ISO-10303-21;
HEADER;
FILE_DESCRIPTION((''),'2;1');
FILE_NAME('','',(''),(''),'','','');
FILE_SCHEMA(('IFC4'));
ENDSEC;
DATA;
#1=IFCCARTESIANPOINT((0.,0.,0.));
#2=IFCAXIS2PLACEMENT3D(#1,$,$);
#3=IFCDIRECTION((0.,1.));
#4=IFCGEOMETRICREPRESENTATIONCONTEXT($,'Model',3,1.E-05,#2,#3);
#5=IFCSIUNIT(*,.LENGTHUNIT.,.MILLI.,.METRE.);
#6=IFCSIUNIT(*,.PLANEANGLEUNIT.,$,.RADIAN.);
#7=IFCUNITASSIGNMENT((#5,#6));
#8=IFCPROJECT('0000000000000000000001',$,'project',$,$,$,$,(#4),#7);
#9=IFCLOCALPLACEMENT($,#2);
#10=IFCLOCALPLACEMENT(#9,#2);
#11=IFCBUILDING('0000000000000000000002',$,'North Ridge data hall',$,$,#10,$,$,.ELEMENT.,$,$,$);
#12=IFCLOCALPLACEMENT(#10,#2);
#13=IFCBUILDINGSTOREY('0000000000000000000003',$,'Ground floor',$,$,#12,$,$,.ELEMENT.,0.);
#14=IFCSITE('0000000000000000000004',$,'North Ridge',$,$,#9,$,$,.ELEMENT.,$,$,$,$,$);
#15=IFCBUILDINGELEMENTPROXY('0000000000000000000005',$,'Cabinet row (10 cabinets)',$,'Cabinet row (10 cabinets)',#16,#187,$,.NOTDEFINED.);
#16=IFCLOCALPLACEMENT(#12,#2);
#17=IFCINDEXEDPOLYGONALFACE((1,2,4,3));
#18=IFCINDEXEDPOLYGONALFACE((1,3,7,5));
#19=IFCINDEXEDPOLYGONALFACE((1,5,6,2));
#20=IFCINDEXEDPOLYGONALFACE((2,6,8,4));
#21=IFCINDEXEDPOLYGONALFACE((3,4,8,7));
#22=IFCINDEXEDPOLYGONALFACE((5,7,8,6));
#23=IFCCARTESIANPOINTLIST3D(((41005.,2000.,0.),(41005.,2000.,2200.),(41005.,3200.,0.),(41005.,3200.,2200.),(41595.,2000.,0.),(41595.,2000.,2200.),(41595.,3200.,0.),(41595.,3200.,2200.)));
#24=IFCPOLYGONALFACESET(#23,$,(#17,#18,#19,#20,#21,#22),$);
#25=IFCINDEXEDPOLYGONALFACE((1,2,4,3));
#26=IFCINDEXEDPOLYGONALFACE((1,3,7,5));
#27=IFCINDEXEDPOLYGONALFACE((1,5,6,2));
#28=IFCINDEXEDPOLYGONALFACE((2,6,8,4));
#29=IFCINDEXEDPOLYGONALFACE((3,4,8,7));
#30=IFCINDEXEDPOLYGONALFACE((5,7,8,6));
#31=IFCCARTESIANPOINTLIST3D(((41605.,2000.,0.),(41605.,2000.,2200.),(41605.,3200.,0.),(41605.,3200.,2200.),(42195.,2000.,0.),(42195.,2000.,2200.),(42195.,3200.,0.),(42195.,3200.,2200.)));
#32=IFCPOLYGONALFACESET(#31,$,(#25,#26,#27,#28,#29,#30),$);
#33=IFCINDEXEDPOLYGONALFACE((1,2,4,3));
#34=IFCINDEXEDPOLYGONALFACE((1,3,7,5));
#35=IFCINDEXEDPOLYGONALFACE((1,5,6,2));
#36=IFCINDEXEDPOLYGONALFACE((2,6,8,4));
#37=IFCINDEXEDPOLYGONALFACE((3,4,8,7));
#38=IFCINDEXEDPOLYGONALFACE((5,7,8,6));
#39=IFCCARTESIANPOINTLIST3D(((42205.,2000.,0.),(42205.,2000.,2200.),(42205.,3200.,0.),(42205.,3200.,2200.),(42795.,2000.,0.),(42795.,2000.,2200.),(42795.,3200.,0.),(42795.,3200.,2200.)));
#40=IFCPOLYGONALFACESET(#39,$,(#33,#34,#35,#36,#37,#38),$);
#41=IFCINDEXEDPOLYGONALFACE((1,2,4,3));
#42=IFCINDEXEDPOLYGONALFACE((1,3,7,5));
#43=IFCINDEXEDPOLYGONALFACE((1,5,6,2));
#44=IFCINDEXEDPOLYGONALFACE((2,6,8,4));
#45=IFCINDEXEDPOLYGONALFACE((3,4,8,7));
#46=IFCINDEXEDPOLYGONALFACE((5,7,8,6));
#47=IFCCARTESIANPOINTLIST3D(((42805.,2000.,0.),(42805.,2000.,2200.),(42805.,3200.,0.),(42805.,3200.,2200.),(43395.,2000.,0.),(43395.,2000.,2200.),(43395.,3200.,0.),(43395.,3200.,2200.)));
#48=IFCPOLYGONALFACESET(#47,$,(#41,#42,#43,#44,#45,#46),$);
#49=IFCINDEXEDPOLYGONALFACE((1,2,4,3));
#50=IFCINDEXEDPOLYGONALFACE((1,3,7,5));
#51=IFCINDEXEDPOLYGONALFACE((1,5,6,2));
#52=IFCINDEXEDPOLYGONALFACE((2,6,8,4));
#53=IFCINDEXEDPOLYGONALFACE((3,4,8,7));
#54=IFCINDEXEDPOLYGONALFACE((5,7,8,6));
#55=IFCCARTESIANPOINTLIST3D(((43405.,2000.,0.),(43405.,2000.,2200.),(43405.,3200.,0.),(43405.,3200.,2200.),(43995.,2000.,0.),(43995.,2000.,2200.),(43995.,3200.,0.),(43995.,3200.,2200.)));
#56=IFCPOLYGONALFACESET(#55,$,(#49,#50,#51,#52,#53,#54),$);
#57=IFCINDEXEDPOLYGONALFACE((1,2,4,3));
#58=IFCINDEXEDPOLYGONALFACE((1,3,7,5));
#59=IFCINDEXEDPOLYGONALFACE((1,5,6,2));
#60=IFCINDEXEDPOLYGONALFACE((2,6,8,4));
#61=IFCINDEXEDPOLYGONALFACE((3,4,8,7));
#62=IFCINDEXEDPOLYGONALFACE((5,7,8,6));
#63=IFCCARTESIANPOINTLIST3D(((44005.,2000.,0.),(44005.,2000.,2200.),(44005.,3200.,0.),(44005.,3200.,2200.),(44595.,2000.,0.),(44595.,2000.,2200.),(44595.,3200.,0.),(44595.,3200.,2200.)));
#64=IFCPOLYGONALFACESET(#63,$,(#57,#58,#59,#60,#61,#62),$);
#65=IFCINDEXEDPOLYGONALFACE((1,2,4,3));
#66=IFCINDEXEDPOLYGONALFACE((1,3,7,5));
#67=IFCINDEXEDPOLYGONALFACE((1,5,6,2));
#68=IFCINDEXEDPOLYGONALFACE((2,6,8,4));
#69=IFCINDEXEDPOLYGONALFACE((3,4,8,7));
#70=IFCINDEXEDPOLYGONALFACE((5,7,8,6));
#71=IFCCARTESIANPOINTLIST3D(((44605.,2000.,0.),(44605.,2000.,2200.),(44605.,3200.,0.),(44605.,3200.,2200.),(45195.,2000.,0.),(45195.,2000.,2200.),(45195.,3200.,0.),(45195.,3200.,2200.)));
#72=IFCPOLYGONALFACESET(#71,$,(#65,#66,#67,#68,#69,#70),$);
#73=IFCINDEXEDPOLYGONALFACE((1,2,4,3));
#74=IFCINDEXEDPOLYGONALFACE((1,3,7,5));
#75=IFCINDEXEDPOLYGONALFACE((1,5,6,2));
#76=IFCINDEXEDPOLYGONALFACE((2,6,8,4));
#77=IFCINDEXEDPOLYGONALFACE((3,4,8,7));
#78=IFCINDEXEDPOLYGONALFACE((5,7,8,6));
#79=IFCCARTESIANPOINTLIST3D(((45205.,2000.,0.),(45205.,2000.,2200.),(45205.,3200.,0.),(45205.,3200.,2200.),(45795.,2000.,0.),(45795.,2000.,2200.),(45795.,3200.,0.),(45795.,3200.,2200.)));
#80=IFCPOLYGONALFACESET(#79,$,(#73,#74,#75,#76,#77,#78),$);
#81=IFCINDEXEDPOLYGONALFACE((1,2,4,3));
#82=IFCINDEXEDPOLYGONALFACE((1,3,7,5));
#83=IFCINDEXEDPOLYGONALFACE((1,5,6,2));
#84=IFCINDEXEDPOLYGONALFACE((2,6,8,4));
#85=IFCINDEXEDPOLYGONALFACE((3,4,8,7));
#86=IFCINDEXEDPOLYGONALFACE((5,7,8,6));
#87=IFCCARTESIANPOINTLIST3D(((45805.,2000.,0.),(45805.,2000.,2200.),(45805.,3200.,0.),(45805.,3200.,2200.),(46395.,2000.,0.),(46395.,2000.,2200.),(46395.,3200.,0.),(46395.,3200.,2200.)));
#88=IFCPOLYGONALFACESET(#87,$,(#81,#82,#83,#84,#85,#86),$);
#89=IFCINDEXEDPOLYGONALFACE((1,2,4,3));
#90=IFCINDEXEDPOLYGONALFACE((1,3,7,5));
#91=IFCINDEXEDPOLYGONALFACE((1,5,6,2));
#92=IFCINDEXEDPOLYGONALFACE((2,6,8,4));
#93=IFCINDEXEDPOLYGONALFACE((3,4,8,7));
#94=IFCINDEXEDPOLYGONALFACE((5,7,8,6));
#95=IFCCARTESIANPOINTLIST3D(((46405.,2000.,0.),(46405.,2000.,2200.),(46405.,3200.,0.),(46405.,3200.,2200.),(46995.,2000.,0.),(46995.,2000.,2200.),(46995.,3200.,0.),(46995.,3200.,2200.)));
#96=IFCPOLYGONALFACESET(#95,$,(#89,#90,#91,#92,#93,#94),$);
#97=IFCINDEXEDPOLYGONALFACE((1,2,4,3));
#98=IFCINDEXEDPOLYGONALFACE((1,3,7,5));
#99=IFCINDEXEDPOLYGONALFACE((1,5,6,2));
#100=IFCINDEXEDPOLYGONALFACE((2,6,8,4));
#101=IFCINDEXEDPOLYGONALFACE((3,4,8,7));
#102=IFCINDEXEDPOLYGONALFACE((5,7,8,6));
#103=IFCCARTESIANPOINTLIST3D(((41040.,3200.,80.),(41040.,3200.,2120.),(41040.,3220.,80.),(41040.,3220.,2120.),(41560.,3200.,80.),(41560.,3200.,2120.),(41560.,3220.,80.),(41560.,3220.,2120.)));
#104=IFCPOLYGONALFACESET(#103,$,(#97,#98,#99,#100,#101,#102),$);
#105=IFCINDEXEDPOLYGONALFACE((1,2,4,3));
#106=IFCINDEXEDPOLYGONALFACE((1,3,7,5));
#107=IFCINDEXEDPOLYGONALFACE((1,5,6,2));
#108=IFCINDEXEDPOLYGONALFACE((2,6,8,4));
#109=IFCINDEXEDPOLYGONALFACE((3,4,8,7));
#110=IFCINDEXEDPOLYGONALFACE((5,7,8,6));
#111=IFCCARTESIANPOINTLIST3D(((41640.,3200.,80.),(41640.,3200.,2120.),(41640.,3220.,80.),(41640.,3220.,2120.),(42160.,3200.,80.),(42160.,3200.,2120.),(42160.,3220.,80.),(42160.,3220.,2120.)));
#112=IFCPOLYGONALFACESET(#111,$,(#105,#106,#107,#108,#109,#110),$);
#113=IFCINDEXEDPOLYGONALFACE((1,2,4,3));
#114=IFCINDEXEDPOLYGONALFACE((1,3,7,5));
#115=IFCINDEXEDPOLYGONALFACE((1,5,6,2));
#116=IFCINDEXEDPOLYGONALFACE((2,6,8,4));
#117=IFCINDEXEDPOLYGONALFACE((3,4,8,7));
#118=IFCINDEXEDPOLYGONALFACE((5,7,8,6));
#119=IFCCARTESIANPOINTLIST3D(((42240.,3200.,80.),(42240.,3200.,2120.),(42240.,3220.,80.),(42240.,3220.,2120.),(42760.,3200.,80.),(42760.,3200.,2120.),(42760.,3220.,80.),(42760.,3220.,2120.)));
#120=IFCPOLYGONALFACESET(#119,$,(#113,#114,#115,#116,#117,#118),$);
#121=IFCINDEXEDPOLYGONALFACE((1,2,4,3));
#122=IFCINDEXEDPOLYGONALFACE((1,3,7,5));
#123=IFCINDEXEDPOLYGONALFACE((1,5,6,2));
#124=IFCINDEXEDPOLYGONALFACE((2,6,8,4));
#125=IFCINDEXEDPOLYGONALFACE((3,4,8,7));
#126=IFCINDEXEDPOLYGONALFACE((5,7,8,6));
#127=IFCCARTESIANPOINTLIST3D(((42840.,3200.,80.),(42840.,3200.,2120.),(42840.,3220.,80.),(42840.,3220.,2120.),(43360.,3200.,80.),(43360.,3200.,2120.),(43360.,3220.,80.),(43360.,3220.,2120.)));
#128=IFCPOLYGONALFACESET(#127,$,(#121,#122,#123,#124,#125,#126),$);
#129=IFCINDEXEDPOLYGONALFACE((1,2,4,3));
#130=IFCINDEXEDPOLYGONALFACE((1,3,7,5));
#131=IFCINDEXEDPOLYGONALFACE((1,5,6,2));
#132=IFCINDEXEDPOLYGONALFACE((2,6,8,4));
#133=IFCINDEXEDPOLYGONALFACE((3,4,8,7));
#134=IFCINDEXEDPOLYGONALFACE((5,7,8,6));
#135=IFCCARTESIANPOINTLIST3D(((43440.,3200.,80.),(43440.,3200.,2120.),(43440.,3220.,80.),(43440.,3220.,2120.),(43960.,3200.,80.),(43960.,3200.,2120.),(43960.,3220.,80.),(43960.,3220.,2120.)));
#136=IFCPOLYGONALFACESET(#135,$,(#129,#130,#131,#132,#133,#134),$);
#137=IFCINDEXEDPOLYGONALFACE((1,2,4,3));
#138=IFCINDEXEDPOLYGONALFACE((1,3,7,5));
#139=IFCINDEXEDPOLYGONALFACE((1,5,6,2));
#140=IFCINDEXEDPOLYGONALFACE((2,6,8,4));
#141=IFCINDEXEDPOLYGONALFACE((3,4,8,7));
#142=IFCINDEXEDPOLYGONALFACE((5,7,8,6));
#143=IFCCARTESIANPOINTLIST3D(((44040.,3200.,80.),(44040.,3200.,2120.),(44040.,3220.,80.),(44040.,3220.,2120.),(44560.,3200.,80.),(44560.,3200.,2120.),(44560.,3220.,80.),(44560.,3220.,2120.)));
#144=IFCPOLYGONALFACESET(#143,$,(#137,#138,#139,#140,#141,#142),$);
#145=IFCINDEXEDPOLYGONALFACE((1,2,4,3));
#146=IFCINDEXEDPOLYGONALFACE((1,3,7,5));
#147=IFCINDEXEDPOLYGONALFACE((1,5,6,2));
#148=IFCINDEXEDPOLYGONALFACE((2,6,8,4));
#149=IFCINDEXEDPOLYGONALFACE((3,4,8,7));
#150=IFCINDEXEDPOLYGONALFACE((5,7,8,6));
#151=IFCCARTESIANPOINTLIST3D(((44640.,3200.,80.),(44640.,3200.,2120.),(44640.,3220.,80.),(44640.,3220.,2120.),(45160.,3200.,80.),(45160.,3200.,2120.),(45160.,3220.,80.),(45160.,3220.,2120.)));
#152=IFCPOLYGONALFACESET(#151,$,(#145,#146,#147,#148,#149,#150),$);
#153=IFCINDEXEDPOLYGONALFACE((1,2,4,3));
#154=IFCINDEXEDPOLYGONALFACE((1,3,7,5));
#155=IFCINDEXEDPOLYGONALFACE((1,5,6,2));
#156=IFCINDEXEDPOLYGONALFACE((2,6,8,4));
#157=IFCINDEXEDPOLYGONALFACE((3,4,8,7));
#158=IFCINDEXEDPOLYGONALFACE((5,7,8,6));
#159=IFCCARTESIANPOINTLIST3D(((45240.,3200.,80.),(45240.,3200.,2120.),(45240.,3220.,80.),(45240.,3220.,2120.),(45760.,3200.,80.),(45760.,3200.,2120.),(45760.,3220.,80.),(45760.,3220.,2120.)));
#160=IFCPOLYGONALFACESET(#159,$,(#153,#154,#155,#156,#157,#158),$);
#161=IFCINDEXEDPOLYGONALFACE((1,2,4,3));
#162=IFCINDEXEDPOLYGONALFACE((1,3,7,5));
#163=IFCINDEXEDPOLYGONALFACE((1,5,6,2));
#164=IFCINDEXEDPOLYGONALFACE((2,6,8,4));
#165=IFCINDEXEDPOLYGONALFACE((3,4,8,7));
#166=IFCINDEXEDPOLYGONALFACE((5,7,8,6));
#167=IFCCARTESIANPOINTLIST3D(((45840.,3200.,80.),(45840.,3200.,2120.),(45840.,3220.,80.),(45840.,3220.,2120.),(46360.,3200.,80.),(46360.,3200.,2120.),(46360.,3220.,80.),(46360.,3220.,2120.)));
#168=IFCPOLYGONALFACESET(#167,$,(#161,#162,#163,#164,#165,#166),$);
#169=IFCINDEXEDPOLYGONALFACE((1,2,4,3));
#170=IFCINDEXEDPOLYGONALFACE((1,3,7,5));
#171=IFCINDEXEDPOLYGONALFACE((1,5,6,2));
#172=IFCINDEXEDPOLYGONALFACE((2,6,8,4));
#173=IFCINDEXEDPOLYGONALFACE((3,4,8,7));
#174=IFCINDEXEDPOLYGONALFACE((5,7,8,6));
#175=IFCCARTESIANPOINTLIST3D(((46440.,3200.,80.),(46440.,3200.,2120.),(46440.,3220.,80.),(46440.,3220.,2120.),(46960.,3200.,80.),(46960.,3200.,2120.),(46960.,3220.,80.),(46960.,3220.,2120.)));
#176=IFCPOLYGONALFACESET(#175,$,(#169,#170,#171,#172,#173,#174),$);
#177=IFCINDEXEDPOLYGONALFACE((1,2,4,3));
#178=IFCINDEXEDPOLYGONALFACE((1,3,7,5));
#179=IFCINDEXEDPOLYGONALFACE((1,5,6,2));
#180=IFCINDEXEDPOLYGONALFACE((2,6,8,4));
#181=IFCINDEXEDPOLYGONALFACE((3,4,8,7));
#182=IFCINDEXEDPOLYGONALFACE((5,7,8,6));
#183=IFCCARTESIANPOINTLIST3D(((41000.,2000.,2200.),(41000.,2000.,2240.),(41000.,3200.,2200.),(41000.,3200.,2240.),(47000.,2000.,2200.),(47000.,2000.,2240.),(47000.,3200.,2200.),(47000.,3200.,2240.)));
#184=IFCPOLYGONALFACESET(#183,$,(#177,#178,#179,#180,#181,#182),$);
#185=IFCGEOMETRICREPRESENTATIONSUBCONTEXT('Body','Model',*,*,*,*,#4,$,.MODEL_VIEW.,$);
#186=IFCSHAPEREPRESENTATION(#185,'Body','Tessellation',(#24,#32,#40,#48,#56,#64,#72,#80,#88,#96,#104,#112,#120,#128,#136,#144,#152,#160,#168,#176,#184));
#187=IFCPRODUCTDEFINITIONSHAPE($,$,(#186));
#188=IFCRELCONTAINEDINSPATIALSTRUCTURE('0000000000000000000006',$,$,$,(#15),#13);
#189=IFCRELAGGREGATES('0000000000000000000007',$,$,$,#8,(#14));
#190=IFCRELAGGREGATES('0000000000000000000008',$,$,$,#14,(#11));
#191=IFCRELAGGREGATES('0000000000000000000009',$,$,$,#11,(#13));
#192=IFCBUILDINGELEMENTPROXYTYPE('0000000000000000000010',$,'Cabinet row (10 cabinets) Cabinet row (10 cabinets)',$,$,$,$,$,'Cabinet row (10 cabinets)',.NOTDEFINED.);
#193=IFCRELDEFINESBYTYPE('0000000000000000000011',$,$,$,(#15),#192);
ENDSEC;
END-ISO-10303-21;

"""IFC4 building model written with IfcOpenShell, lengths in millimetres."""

from ifc_helpers import new_model, si_unit, direction, frame, origin, place, context, subcontext, project, spatial, polyline, outline, extrude, source, transform, mapped, type_object, type_shapes, element, save


model = new_model("IFC4")

# Units and contexts
model_context = context("Model", 3, precision=1e-05, world=origin(), true_north=direction((0.0, 1.0)))
body_context = subcontext(model_context, "Body", "Model", "MODEL_VIEW")
ifc_project = project(units=[si_unit("LENGTHUNIT", "METRE", prefix="MILLI"), si_unit("PLANEANGLEUNIT", "RADIAN")], contexts=[model_context])

# Site, building, storey
site_placement = place(None, origin())
site = spatial("IfcSite", under=ifc_project, at=site_placement, Name="North Ridge", CompositionType="ELEMENT")
building_placement = place(site_placement, origin())
building = spatial("IfcBuilding", under=site, at=building_placement, Name="North Ridge data hall", CompositionType="ELEMENT")
storey_placement = place(building_placement, origin())
storey = spatial("IfcBuildingStorey", under=building, at=storey_placement, Name="Ground floor", CompositionType="ELEMENT", Elevation=0.0)

# Building element proxy
building_element_proxy_type_1 = type_object("IfcBuildingElementProxyType", Name="Cabinet row (10 cabinets) Cabinet row (10 cabinets)", ElementType="Cabinet row (10 cabinets)", PredefinedType="NOTDEFINED")
shared_shape_1 = source(origin(), body_context, "Body", "SweptSolid", [
    extrude(outline(polyline([(5.0, 0.0), (595.0, 0.0), (595.0, 1200.0), (5.0, 1200.0), (5.0, 0.0)])), origin(), (0.0, 0.0, 1.0), 2200.0),
    extrude(outline(polyline([(605.0, 0.0), (1195.0, 0.0), (1195.0, 1200.0), (605.0, 1200.0), (605.0, 0.0)])), origin(), (0.0, 0.0, 1.0), 2200.0),
    extrude(outline(polyline([(1205.0, 0.0), (1795.0, 0.0), (1795.0, 1200.0), (1205.0, 1200.0), (1205.0, 0.0)])), origin(), (0.0, 0.0, 1.0), 2200.0),
    extrude(outline(polyline([(1805.0, 0.0), (2395.0, 0.0), (2395.0, 1200.0), (1805.0, 1200.0), (1805.0, 0.0)])), origin(), (0.0, 0.0, 1.0), 2200.0),
    extrude(outline(polyline([(2405.0, 0.0), (2995.0, 0.0), (2995.0, 1200.0), (2405.0, 1200.0), (2405.0, 0.0)])), origin(), (0.0, 0.0, 1.0), 2200.0),
    extrude(outline(polyline([(3005.0, 0.0), (3595.0, 0.0), (3595.0, 1200.0), (3005.0, 1200.0), (3005.0, 0.0)])), origin(), (0.0, 0.0, 1.0), 2200.0),
    extrude(outline(polyline([(3605.0, 0.0), (4195.0, 0.0), (4195.0, 1200.0), (3605.0, 1200.0), (3605.0, 0.0)])), origin(), (0.0, 0.0, 1.0), 2200.0),
    extrude(outline(polyline([(4205.0, 0.0), (4795.0, 0.0), (4795.0, 1200.0), (4205.0, 1200.0), (4205.0, 0.0)])), origin(), (0.0, 0.0, 1.0), 2200.0),
    extrude(outline(polyline([(4805.0, 0.0), (5395.0, 0.0), (5395.0, 1200.0), (4805.0, 1200.0), (4805.0, 0.0)])), origin(), (0.0, 0.0, 1.0), 2200.0),
    extrude(outline(polyline([(5405.0, 0.0), (5995.0, 0.0), (5995.0, 1200.0), (5405.0, 1200.0), (5405.0, 0.0)])), origin(), (0.0, 0.0, 1.0), 2200.0),
    extrude(outline(polyline([(40.0, 1200.0), (560.0, 1200.0), (560.0, 1220.0), (40.0, 1220.0), (40.0, 1200.0)])), frame((0.0, 0.0, 80.0)), (0.0, 0.0, 1.0), 2040.0),
    extrude(outline(polyline([(640.0, 1200.0), (1160.0, 1200.0), (1160.0, 1220.0), (640.0, 1220.0), (640.0, 1200.0)])), frame((0.0, 0.0, 80.0)), (0.0, 0.0, 1.0), 2040.0),
    extrude(outline(polyline([(1240.0, 1200.0), (1760.0, 1200.0), (1760.0, 1220.0), (1240.0, 1220.0), (1240.0, 1200.0)])), frame((0.0, 0.0, 80.0)), (0.0, 0.0, 1.0), 2040.0),
    extrude(outline(polyline([(1840.0, 1200.0), (2360.0, 1200.0), (2360.0, 1220.0), (1840.0, 1220.0), (1840.0, 1200.0)])), frame((0.0, 0.0, 80.0)), (0.0, 0.0, 1.0), 2040.0),
    extrude(outline(polyline([(2440.0, 1200.0), (2960.0, 1200.0), (2960.0, 1220.0), (2440.0, 1220.0), (2440.0, 1200.0)])), frame((0.0, 0.0, 80.0)), (0.0, 0.0, 1.0), 2040.0),
    extrude(outline(polyline([(3040.0, 1200.0), (3560.0, 1200.0), (3560.0, 1220.0), (3040.0, 1220.0), (3040.0, 1200.0)])), frame((0.0, 0.0, 80.0)), (0.0, 0.0, 1.0), 2040.0),
    extrude(outline(polyline([(3640.0, 1200.0), (4160.0, 1200.0), (4160.0, 1220.0), (3640.0, 1220.0), (3640.0, 1200.0)])), frame((0.0, 0.0, 80.0)), (0.0, 0.0, 1.0), 2040.0),
    extrude(outline(polyline([(4240.0, 1200.0), (4760.0, 1200.0), (4760.0, 1220.0), (4240.0, 1220.0), (4240.0, 1200.0)])), frame((0.0, 0.0, 80.0)), (0.0, 0.0, 1.0), 2040.0),
    extrude(outline(polyline([(4840.0, 1200.0), (5360.0, 1200.0), (5360.0, 1220.0), (4840.0, 1220.0), (4840.0, 1200.0)])), frame((0.0, 0.0, 80.0)), (0.0, 0.0, 1.0), 2040.0),
    extrude(outline(polyline([(5440.0, 1200.0), (5960.0, 1200.0), (5960.0, 1220.0), (5440.0, 1220.0), (5440.0, 1200.0)])), frame((0.0, 0.0, 80.0)), (0.0, 0.0, 1.0), 2040.0),
    extrude(outline(polyline([(0.0, 0.0), (6000.0, 0.0), (6000.0, 1200.0), (0.0, 1200.0), (0.0, 0.0)])), frame((0.0, 0.0, 2200.0)), (0.0, 0.0, 1.0), 40.0),
])
type_shapes(building_element_proxy_type_1, [shared_shape_1])
for number, where, z_axis, x_axis, name in (
    (1, (41000.0, 2000.0, 0.0), (0.0, 0.0, 1.0), (1.0, 0.0, 0.0), "Cabinet row (10 cabinets)"),
):
    element("IfcBuildingElementProxy", number, at=place(storey_placement, frame(where, z_axis=z_axis, x_axis=x_axis)), inside=storey, type_object=building_element_proxy_type_1, Name=name, ObjectType="Cabinet row (10 cabinets)", PredefinedType="NOTDEFINED", context=body_context, shape_type="MappedRepresentation", body=[
        mapped(shared_shape_1, transform((0.0, 0.0, 0.0))),
    ])

save(model, "model.ifc")
